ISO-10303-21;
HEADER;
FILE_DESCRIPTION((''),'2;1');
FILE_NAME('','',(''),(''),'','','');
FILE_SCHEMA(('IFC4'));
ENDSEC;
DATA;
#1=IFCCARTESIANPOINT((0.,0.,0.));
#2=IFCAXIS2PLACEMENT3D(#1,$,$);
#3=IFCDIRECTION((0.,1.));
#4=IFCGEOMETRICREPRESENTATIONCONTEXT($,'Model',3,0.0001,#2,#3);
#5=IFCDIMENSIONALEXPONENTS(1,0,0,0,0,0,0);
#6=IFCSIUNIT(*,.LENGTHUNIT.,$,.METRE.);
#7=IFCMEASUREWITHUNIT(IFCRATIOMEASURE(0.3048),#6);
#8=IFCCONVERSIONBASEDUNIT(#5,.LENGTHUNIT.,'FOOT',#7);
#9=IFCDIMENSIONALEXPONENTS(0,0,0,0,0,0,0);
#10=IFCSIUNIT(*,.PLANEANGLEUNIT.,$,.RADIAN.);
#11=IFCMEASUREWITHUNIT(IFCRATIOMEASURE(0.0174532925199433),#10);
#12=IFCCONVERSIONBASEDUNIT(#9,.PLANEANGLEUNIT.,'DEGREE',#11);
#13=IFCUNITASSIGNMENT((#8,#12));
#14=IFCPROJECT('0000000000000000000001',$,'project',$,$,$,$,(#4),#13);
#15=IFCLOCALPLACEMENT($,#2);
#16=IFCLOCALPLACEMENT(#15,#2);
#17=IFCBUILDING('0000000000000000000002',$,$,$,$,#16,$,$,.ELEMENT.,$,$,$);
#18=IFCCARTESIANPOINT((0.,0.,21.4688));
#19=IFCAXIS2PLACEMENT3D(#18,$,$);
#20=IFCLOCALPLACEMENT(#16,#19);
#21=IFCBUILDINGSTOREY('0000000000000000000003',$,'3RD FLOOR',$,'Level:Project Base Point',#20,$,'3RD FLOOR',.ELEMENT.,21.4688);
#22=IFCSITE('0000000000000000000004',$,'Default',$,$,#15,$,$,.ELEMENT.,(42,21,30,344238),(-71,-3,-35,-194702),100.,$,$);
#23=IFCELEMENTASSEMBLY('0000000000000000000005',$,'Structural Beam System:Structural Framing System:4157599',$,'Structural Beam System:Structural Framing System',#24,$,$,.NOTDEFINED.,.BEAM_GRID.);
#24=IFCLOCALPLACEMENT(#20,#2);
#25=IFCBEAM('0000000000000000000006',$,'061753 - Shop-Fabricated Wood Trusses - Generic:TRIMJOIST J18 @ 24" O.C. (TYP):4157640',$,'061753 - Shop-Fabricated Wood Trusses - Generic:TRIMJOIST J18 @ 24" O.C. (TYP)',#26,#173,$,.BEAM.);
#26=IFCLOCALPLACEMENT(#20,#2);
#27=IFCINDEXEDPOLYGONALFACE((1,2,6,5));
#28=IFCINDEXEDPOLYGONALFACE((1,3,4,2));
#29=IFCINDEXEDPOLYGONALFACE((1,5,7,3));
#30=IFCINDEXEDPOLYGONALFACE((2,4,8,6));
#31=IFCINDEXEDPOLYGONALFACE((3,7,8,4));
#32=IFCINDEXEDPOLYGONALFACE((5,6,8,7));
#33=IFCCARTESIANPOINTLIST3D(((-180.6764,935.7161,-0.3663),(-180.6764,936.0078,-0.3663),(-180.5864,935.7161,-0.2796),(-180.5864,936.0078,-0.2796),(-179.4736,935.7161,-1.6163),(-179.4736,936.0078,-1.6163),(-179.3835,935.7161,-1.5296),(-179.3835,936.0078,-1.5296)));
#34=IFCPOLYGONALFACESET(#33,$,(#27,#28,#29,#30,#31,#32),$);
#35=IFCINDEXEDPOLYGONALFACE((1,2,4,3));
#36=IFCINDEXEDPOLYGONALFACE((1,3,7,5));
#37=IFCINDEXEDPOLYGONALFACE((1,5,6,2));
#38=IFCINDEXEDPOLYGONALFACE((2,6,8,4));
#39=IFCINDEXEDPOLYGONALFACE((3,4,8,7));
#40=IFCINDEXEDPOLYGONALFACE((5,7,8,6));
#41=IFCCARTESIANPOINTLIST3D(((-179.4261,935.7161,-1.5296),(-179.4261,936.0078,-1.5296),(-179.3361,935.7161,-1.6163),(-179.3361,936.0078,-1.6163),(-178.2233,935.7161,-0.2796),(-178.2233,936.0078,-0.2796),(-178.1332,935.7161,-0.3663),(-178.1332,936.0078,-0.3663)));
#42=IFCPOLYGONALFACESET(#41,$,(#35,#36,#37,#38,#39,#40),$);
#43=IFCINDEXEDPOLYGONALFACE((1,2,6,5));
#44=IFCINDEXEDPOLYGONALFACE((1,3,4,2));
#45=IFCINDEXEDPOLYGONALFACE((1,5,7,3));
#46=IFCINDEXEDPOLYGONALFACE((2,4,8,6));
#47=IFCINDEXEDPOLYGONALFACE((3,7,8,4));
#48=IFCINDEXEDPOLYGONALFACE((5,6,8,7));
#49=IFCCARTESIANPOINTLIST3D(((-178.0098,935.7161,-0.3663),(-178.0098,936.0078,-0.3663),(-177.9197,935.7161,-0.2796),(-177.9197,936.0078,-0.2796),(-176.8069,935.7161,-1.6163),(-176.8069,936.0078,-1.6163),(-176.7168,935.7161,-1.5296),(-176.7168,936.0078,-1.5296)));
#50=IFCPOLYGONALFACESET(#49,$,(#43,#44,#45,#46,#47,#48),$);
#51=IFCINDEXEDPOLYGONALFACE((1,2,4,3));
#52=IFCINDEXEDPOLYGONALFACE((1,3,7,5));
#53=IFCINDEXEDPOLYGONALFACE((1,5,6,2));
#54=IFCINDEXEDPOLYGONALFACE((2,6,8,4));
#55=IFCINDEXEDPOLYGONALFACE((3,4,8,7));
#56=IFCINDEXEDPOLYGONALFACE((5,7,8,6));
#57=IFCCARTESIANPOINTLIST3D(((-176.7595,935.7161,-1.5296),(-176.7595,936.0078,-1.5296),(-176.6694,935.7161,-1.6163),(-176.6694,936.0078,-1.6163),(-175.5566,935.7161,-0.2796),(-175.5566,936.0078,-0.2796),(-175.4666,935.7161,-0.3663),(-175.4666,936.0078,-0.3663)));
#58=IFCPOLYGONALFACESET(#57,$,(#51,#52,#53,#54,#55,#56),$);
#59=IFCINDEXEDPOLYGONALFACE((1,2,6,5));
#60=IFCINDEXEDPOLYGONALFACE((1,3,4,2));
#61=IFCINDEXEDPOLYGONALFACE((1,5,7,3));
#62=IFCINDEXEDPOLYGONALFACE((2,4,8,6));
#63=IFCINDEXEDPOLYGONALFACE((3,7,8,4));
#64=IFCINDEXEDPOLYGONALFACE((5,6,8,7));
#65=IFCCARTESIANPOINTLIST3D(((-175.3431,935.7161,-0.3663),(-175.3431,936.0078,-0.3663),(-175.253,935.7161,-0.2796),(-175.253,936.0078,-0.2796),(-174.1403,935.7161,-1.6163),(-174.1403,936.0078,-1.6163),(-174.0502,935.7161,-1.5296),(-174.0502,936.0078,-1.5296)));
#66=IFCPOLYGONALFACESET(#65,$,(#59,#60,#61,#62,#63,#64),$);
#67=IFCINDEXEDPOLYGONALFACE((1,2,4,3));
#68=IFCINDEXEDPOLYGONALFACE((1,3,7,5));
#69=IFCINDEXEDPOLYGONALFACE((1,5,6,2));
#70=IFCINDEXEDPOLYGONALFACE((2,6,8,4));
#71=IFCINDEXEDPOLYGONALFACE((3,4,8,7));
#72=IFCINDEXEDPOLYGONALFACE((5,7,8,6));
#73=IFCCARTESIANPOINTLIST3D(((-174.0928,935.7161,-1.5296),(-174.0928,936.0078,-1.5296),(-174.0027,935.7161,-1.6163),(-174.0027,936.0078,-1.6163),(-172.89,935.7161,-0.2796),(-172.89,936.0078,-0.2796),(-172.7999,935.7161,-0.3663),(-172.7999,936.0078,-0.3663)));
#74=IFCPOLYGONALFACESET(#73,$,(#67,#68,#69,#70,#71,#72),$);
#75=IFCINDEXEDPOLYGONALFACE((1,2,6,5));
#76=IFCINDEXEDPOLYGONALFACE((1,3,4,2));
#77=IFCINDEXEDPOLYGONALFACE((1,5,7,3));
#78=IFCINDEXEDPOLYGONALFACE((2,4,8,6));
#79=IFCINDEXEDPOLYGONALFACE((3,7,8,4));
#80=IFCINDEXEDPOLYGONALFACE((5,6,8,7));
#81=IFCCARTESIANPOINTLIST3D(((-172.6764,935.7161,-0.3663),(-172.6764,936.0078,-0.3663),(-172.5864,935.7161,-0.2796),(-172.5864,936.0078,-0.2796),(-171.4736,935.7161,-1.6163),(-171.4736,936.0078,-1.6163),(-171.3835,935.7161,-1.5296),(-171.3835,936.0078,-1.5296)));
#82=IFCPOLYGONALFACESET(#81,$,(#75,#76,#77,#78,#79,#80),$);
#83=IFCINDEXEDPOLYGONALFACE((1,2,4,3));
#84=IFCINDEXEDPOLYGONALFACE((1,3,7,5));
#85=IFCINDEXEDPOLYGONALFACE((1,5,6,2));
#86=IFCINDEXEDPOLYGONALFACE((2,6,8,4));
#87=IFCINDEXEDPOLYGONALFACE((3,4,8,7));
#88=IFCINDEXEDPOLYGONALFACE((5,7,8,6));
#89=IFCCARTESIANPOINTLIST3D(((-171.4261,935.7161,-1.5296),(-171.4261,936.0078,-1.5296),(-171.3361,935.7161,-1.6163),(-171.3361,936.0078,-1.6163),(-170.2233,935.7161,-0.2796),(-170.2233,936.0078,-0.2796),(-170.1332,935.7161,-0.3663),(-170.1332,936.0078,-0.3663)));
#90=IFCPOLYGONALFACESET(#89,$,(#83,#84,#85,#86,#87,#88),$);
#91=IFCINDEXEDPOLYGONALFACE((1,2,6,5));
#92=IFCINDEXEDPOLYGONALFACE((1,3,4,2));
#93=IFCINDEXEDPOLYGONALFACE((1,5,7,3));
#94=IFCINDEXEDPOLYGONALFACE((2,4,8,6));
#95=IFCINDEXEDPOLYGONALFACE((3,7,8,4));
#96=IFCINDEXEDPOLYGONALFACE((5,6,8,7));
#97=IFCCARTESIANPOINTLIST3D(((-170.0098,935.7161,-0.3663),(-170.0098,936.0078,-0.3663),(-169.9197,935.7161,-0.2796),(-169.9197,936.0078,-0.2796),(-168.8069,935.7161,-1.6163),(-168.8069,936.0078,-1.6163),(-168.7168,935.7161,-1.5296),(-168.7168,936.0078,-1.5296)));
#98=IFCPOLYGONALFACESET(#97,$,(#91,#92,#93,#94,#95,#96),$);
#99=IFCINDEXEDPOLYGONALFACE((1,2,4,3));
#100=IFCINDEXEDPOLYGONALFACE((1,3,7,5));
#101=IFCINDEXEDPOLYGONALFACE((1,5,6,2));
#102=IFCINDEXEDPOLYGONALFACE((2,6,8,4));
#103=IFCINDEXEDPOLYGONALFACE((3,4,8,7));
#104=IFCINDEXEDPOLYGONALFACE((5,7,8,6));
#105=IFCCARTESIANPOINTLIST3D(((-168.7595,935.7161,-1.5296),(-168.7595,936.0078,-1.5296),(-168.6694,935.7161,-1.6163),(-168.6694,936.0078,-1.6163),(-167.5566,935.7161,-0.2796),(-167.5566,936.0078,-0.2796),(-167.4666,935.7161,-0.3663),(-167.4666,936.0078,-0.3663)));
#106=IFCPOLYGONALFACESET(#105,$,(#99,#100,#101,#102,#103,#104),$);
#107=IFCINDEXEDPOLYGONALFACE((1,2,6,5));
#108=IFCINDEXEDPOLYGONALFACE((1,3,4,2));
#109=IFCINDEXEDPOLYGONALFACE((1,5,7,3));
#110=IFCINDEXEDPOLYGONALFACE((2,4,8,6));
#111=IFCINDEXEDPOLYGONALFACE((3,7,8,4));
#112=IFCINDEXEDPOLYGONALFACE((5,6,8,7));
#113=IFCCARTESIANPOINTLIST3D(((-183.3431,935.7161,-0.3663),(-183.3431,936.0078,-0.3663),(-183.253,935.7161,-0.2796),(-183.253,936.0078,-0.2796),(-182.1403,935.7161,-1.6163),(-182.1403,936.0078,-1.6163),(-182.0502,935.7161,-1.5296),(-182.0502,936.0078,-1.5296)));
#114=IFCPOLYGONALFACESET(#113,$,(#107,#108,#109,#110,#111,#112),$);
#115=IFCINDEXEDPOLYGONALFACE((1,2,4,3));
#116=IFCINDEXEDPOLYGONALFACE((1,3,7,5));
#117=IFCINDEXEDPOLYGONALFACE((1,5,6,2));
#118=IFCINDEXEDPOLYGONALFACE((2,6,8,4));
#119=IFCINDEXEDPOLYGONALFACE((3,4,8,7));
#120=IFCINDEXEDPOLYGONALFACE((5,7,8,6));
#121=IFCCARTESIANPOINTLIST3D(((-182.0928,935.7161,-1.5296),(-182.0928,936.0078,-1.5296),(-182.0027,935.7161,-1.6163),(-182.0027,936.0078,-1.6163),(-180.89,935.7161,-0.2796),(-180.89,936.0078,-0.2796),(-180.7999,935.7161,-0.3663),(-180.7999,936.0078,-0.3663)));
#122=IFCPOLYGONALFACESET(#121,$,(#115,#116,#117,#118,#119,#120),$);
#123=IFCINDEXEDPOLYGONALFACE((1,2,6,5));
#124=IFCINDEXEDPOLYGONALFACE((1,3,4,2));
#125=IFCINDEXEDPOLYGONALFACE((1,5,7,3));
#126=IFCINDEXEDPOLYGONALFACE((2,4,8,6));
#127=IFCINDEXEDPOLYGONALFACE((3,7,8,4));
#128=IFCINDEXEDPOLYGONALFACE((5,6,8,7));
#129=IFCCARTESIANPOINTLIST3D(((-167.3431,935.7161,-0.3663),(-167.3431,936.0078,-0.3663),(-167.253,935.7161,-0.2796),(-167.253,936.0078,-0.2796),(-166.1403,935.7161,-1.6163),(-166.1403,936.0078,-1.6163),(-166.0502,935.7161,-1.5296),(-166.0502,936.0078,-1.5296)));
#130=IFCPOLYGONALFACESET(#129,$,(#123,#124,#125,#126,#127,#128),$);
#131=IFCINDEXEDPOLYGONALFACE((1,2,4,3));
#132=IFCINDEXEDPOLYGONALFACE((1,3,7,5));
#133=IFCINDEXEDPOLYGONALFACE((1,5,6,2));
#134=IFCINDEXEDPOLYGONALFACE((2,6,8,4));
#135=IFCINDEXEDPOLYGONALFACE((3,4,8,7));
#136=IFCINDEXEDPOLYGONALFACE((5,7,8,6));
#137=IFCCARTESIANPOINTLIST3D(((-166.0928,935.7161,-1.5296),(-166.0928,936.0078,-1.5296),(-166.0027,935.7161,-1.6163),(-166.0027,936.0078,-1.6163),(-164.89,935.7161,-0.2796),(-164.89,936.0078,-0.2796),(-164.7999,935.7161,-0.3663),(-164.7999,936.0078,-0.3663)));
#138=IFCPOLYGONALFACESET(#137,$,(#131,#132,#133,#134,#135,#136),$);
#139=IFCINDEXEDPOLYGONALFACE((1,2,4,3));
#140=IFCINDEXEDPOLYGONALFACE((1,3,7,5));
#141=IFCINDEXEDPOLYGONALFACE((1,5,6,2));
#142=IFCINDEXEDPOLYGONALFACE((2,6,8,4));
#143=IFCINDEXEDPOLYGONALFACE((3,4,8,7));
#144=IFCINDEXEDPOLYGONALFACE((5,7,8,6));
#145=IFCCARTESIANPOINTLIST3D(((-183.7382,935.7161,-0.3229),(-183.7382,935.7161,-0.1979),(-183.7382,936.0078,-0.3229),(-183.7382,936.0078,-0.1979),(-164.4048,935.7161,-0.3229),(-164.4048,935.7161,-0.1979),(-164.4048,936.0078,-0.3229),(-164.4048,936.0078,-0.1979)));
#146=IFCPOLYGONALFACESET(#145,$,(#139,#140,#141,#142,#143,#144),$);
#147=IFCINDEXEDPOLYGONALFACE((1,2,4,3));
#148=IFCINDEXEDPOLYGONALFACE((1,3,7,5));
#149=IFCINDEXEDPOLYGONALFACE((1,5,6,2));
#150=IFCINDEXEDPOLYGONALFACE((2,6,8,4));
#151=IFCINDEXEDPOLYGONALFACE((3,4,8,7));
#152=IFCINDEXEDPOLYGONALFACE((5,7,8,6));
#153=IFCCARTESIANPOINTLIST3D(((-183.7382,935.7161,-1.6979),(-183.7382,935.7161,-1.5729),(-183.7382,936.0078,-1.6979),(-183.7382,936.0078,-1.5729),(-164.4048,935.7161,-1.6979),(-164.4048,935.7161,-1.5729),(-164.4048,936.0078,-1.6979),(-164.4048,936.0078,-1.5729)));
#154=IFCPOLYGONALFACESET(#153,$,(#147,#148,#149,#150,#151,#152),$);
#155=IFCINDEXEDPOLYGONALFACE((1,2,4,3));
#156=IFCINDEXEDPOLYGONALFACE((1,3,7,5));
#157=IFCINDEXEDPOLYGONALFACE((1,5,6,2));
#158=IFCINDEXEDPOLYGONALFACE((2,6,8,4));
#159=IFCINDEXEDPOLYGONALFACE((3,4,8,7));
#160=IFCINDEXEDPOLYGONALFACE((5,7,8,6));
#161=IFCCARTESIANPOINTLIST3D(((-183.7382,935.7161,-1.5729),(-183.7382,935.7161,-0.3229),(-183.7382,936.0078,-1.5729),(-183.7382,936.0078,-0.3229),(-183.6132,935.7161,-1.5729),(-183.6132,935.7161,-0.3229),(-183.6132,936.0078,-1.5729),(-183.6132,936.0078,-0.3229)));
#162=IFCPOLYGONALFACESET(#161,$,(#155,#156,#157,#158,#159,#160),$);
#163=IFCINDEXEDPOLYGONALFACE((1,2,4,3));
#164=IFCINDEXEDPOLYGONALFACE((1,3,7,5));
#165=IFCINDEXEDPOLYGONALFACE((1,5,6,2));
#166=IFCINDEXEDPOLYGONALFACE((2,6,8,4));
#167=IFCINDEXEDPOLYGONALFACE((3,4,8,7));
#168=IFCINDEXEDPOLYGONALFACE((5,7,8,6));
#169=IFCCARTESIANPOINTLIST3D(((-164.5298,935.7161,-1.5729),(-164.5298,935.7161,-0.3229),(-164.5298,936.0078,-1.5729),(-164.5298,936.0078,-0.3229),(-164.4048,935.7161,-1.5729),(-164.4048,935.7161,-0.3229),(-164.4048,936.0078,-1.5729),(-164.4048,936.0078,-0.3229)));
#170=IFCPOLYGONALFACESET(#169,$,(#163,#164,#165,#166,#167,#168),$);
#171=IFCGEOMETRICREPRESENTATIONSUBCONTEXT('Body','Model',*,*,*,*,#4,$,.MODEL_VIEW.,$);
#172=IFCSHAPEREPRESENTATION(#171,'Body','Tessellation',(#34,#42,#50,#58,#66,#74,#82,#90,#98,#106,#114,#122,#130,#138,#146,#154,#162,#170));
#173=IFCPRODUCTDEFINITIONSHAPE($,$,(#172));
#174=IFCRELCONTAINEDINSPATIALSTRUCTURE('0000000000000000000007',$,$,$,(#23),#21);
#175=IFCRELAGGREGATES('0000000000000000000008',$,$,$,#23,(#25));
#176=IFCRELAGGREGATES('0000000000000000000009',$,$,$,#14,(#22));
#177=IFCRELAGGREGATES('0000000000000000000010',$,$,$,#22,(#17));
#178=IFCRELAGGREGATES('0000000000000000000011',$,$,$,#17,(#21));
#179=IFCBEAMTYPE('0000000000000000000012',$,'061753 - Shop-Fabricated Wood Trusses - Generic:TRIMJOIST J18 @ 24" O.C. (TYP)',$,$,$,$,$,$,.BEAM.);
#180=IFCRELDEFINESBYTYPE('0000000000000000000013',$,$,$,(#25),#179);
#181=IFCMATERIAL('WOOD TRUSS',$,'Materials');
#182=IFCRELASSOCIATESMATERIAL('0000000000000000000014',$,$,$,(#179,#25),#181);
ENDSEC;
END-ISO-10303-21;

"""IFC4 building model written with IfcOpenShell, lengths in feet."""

from ifc_helpers import new_model, entity, si_unit, converted_unit, direction, frame, frame_2d, origin, origin_2d_with_axis, place, context, subcontext, project, spatial, rectangle, extrude, source, transform, mapped, material, material_profile, profile_set, profile_usage, type_object, type_shapes, element, aggregate, save


model = new_model("IFC4")

# Units and contexts
model_context = context("Model", 3, precision=0.0001, world=origin(), true_north=direction((0.0, 1.0)))
body_context = subcontext(model_context, "Body", "Model", "MODEL_VIEW")
ifc_project = project(units=[converted_unit("LENGTHUNIT", "FOOT", entity("IfcRatioMeasure", 0.3048), si_unit("LENGTHUNIT", "METRE"), dimensions=[1, 0, 0, 0, 0, 0, 0]), converted_unit("PLANEANGLEUNIT", "DEGREE", entity("IfcRatioMeasure", 0.0174532925199433), si_unit("PLANEANGLEUNIT", "RADIAN"), dimensions=[0, 0, 0, 0, 0, 0, 0])], contexts=[model_context])

# Site, building, storey
site_placement = place(None, origin())
site = spatial("IfcSite", under=ifc_project, at=site_placement, Name="Default", CompositionType="ELEMENT", RefLatitude=(42, 21, 30, 344238), RefLongitude=(-71, -3, -35, -194702), RefElevation=100.0)
building_placement = place(site_placement, origin())
building = spatial("IfcBuilding", under=site, at=building_placement, CompositionType="ELEMENT")
storey_placement = place(building_placement, frame((0.0, 0.0, 21.4688)))
storey = spatial("IfcBuildingStorey", under=building, at=storey_placement, Name="3RD FLOOR", ObjectType="Level:Project Base Point", LongName="3RD FLOOR", CompositionType="ELEMENT", Elevation=21.4688)

# Element assembly, beam
ifc_material = material(Name="WOOD TRUSS", Category="Materials")
ifc_material_profile_1 = material_profile(ifc_material, rectangle(XDim=1.7347, YDim=0.125, at=frame_2d((0.0, 0.0), x_axis=(1.0, 0.0))), Name="TRIMJOIST J18 @ 24\" O.C. (TYP)")
ifc_material_profile_2 = material_profile(ifc_material, rectangle(XDim=1.7347, YDim=0.125, at=frame_2d((0.0, 0.0), x_axis=(1.0, 0.0))), Name="TRIMJOIST J18 @ 24\" O.C. (TYP)")
ifc_material_profile_3 = material_profile(ifc_material, rectangle(XDim=1.7347, YDim=0.125, at=frame_2d((0.0, 0.0), x_axis=(1.0, 0.0))), Name="TRIMJOIST J18 @ 24\" O.C. (TYP)")
ifc_material_profile_4 = material_profile(ifc_material, rectangle(XDim=1.7347, YDim=0.125, at=frame_2d((0.0, 0.0), x_axis=(1.0, 0.0))), Name="TRIMJOIST J18 @ 24\" O.C. (TYP)")
ifc_material_profile_5 = material_profile(ifc_material, rectangle(XDim=1.7347, YDim=0.125, at=frame_2d((0.0, 0.0), x_axis=(1.0, 0.0))), Name="TRIMJOIST J18 @ 24\" O.C. (TYP)")
ifc_material_profile_6 = material_profile(ifc_material, rectangle(XDim=1.7347, YDim=0.125, at=frame_2d((0.0, 0.0), x_axis=(1.0, 0.0))), Name="TRIMJOIST J18 @ 24\" O.C. (TYP)")
ifc_material_profile_7 = material_profile(ifc_material, rectangle(XDim=1.7347, YDim=0.125, at=frame_2d((0.0, 0.0), x_axis=(1.0, 0.0))), Name="TRIMJOIST J18 @ 24\" O.C. (TYP)")
ifc_material_profile_8 = material_profile(ifc_material, rectangle(XDim=1.7347, YDim=0.125, at=frame_2d((0.0, 0.0), x_axis=(1.0, 0.0))), Name="TRIMJOIST J18 @ 24\" O.C. (TYP)")
ifc_material_profile_9 = material_profile(ifc_material, rectangle(XDim=1.7347, YDim=0.125, at=frame_2d((0.0, 0.0), x_axis=(1.0, 0.0))), Name="TRIMJOIST J18 @ 24\" O.C. (TYP)")
ifc_material_profile_10 = material_profile(ifc_material, rectangle(XDim=1.7347, YDim=0.125, at=origin_2d_with_axis()), Name="TRIMJOIST J18 @ 24\" O.C. (TYP)")
ifc_material_profile_11 = material_profile(ifc_material, rectangle(XDim=0.125, YDim=0.2917, at=origin_2d_with_axis()), Name="TRIMJOIST J18 @ 24\" O.C. (TYP)")
ifc_material_profile_12 = material_profile(ifc_material, rectangle(XDim=0.125, YDim=0.2917, at=origin_2d_with_axis()), Name="TRIMJOIST J18 @ 24\" O.C. (TYP)")
ifc_material_profile_13 = material_profile(ifc_material, rectangle(XDim=1.25, YDim=0.2917, at=origin_2d_with_axis()), Name="TRIMJOIST J18 @ 24\" O.C. (TYP)")
ifc_material_profile_14 = material_profile(ifc_material, rectangle(XDim=1.25, YDim=0.2917, at=origin_2d_with_axis()), Name="TRIMJOIST J18 @ 24\" O.C. (TYP)")
ifc_profile_set = profile_set([ifc_material_profile_1, ifc_material_profile_2, ifc_material_profile_3, ifc_material_profile_4, ifc_material_profile_5, ifc_material_profile_6, ifc_material_profile_7, ifc_material_profile_8, ifc_material_profile_9, ifc_material_profile_10, ifc_material_profile_11, ifc_material_profile_12, ifc_material_profile_13, ifc_material_profile_14], Name="TRIMJOIST J18 @ 24\" O.C. (TYP)")
assembly_1_placement = place(storey_placement, origin())
assembly_1 = element("IfcElementAssembly", 1, at=assembly_1_placement, inside=storey, Name="Structural Beam System:Structural Framing System:4157599", ObjectType="Structural Beam System:Structural Framing System", AssemblyPlace="NOTDEFINED", PredefinedType="BEAM_GRID")
beam_type_1 = type_object("IfcBeamType", Name="061753 - Shop-Fabricated Wood Trusses - Generic:TRIMJOIST J18 @ 24\" O.C. (TYP)", PredefinedType="BEAM", material=ifc_profile_set)
shared_shape_1 = source(origin(), body_context, "Body", "SweptSolid", [
    extrude(rectangle(XDim=1.7347, YDim=0.125, at=frame_2d((0.0, 0.0), x_axis=(1.0, 0.0))), frame((5.9585, -0.1458, 0.0), z_axis=(0.0, 1.0, 0.0), x_axis=(0.693383, 0.0, 0.720569)), (0.0, 0.0, 1.0), 0.2917),
    extrude(rectangle(XDim=1.7347, YDim=0.125, at=origin_2d_with_axis()), frame((4.7082, -0.1458, 0.0), z_axis=(0.0, 1.0, 0.0), x_axis=(0.693383, 0.0, -0.720569)), (0.0, 0.0, 1.0), 0.2917),
    extrude(rectangle(XDim=1.7347, YDim=0.125, at=frame_2d((0.0, 0.0), x_axis=(1.0, 0.0))), frame((3.2918, -0.1458, 0.0), z_axis=(0.0, 1.0, 0.0), x_axis=(0.693383, 0.0, 0.720569)), (0.0, 0.0, 1.0), 0.2917),
    extrude(rectangle(XDim=1.7347, YDim=0.125, at=frame_2d((0.0, 0.0), x_axis=(1.0, 0.0))), frame((2.0415, -0.1458, 0.0), z_axis=(0.0, 1.0, 0.0), x_axis=(0.693383, 0.0, -0.720569)), (0.0, 0.0, 1.0), 0.2917),
    extrude(rectangle(XDim=1.7347, YDim=0.125, at=frame_2d((0.0, 0.0), x_axis=(1.0, 0.0))), frame((0.6251, -0.1458, 0.0), z_axis=(0.0, 1.0, 0.0), x_axis=(0.693383, 0.0, 0.720569)), (0.0, 0.0, 1.0), 0.2917),
    extrude(rectangle(XDim=1.7347, YDim=0.125, at=frame_2d((0.0, 0.0), x_axis=(1.0, 0.0))), frame((-0.6251, -0.1458, 0.0), z_axis=(0.0, 1.0, 0.0), x_axis=(0.693383, 0.0, -0.720569)), (0.0, 0.0, 1.0), 0.2917),
    extrude(rectangle(XDim=1.7347, YDim=0.125, at=frame_2d((0.0, 0.0), x_axis=(1.0, 0.0))), frame((-2.0415, -0.1458, 0.0), z_axis=(0.0, 1.0, 0.0), x_axis=(0.693383, 0.0, 0.720569)), (0.0, 0.0, 1.0), 0.2917),
    extrude(rectangle(XDim=1.7347, YDim=0.125, at=origin_2d_with_axis()), frame((-3.2918, -0.1458, 0.0), z_axis=(0.0, 1.0, 0.0), x_axis=(0.693383, 0.0, -0.720569)), (0.0, 0.0, 1.0), 0.2917),
    extrude(rectangle(XDim=1.7347, YDim=0.125, at=frame_2d((0.0, 0.0), x_axis=(1.0, 0.0))), frame((-4.7082, -0.1458, 0.0), z_axis=(0.0, 1.0, 0.0), x_axis=(0.693383, 0.0, 0.720569)), (0.0, 0.0, 1.0), 0.2917),
    extrude(rectangle(XDim=1.7347, YDim=0.125, at=frame_2d((0.0, 0.0), x_axis=(1.0, 0.0))), frame((-5.9585, -0.1458, 0.0), z_axis=(0.0, 1.0, 0.0), x_axis=(0.693383, 0.0, -0.720569)), (0.0, 0.0, 1.0), 0.2917),
    extrude(rectangle(XDim=1.7347, YDim=0.125, at=frame_2d((0.0, 0.0), x_axis=(1.0, 0.0))), frame((8.6251, -0.1458, 0.0), z_axis=(0.0, 1.0, 0.0), x_axis=(0.693383, 0.0, 0.720569)), (0.0, 0.0, 1.0), 0.2917),
    extrude(rectangle(XDim=1.7347, YDim=0.125, at=origin_2d_with_axis()), frame((7.3749, -0.1458, 0.0), z_axis=(0.0, 1.0, 0.0), x_axis=(0.693383, 0.0, -0.720569)), (0.0, 0.0, 1.0), 0.2917),
    extrude(rectangle(XDim=1.7347, YDim=0.125, at=frame_2d((0.0, 0.0), x_axis=(1.0, 0.0))), frame((-7.3749, -0.1458, 0.0), z_axis=(0.0, 1.0, 0.0), x_axis=(0.693383, 0.0, 0.720569)), (0.0, 0.0, 1.0), 0.2917),
    extrude(rectangle(XDim=1.7347, YDim=0.125, at=origin_2d_with_axis()), frame((-8.6251, -0.1458, 0.0), z_axis=(0.0, 1.0, 0.0), x_axis=(0.693383, 0.0, -0.720569)), (0.0, 0.0, 1.0), 0.2917),
    extrude(rectangle(XDim=0.125, YDim=0.2917, at=origin_2d_with_axis()), frame((-9.6667, 0.0, 0.6875), z_axis=(1.0, 0.0, 0.0), x_axis=(0.0, 0.0, -1.0)), (0.0, 0.0, 1.0), 19.3333),
    extrude(rectangle(XDim=0.125, YDim=0.2917, at=origin_2d_with_axis()), frame((-9.6667, 0.0, -0.6875), z_axis=(1.0, 0.0, 0.0), x_axis=(0.0, 0.0, -1.0)), (0.0, 0.0, 1.0), 19.3333),
    extrude(rectangle(XDim=1.25, YDim=0.2917, at=origin_2d_with_axis()), frame((9.5417, 0.0, 0.0), z_axis=(1.0, 0.0, 0.0), x_axis=(0.0, 0.0, -1.0)), (0.0, 0.0, 1.0), 0.125),
    extrude(rectangle(XDim=1.25, YDim=0.2917, at=origin_2d_with_axis()), frame((-9.6667, 0.0, 0.0), z_axis=(1.0, 0.0, 0.0), x_axis=(0.0, 0.0, -1.0)), (0.0, 0.0, 1.0), 0.125),
])
type_shapes(beam_type_1, [shared_shape_1])
ifc_profile_usage_1 = profile_usage(ifc_profile_set, cardinal=8)
beam_1_placement = place(assembly_1_placement, frame((-174.0715, 935.8619, -0.9479), z_axis=(0.0, 0.0, 1.0), x_axis=(-1.0, 0.0, 0.0)))
beam_1 = element("IfcBeam", 2, at=beam_1_placement, type_object=beam_type_1, material=ifc_profile_usage_1, Name="061753 - Shop-Fabricated Wood Trusses - Generic:TRIMJOIST J18 @ 24\" O.C. (TYP):4157640", ObjectType="061753 - Shop-Fabricated Wood Trusses - Generic:TRIMJOIST J18 @ 24\" O.C. (TYP)", PredefinedType="BEAM", context=body_context, shape_type="MappedRepresentation", body=[
    mapped(shared_shape_1, transform((0.0, 0.0, 0.0), scale=1.0)),
])
aggregate(assembly_1, [beam_1])

save(model, "model.ifc")
